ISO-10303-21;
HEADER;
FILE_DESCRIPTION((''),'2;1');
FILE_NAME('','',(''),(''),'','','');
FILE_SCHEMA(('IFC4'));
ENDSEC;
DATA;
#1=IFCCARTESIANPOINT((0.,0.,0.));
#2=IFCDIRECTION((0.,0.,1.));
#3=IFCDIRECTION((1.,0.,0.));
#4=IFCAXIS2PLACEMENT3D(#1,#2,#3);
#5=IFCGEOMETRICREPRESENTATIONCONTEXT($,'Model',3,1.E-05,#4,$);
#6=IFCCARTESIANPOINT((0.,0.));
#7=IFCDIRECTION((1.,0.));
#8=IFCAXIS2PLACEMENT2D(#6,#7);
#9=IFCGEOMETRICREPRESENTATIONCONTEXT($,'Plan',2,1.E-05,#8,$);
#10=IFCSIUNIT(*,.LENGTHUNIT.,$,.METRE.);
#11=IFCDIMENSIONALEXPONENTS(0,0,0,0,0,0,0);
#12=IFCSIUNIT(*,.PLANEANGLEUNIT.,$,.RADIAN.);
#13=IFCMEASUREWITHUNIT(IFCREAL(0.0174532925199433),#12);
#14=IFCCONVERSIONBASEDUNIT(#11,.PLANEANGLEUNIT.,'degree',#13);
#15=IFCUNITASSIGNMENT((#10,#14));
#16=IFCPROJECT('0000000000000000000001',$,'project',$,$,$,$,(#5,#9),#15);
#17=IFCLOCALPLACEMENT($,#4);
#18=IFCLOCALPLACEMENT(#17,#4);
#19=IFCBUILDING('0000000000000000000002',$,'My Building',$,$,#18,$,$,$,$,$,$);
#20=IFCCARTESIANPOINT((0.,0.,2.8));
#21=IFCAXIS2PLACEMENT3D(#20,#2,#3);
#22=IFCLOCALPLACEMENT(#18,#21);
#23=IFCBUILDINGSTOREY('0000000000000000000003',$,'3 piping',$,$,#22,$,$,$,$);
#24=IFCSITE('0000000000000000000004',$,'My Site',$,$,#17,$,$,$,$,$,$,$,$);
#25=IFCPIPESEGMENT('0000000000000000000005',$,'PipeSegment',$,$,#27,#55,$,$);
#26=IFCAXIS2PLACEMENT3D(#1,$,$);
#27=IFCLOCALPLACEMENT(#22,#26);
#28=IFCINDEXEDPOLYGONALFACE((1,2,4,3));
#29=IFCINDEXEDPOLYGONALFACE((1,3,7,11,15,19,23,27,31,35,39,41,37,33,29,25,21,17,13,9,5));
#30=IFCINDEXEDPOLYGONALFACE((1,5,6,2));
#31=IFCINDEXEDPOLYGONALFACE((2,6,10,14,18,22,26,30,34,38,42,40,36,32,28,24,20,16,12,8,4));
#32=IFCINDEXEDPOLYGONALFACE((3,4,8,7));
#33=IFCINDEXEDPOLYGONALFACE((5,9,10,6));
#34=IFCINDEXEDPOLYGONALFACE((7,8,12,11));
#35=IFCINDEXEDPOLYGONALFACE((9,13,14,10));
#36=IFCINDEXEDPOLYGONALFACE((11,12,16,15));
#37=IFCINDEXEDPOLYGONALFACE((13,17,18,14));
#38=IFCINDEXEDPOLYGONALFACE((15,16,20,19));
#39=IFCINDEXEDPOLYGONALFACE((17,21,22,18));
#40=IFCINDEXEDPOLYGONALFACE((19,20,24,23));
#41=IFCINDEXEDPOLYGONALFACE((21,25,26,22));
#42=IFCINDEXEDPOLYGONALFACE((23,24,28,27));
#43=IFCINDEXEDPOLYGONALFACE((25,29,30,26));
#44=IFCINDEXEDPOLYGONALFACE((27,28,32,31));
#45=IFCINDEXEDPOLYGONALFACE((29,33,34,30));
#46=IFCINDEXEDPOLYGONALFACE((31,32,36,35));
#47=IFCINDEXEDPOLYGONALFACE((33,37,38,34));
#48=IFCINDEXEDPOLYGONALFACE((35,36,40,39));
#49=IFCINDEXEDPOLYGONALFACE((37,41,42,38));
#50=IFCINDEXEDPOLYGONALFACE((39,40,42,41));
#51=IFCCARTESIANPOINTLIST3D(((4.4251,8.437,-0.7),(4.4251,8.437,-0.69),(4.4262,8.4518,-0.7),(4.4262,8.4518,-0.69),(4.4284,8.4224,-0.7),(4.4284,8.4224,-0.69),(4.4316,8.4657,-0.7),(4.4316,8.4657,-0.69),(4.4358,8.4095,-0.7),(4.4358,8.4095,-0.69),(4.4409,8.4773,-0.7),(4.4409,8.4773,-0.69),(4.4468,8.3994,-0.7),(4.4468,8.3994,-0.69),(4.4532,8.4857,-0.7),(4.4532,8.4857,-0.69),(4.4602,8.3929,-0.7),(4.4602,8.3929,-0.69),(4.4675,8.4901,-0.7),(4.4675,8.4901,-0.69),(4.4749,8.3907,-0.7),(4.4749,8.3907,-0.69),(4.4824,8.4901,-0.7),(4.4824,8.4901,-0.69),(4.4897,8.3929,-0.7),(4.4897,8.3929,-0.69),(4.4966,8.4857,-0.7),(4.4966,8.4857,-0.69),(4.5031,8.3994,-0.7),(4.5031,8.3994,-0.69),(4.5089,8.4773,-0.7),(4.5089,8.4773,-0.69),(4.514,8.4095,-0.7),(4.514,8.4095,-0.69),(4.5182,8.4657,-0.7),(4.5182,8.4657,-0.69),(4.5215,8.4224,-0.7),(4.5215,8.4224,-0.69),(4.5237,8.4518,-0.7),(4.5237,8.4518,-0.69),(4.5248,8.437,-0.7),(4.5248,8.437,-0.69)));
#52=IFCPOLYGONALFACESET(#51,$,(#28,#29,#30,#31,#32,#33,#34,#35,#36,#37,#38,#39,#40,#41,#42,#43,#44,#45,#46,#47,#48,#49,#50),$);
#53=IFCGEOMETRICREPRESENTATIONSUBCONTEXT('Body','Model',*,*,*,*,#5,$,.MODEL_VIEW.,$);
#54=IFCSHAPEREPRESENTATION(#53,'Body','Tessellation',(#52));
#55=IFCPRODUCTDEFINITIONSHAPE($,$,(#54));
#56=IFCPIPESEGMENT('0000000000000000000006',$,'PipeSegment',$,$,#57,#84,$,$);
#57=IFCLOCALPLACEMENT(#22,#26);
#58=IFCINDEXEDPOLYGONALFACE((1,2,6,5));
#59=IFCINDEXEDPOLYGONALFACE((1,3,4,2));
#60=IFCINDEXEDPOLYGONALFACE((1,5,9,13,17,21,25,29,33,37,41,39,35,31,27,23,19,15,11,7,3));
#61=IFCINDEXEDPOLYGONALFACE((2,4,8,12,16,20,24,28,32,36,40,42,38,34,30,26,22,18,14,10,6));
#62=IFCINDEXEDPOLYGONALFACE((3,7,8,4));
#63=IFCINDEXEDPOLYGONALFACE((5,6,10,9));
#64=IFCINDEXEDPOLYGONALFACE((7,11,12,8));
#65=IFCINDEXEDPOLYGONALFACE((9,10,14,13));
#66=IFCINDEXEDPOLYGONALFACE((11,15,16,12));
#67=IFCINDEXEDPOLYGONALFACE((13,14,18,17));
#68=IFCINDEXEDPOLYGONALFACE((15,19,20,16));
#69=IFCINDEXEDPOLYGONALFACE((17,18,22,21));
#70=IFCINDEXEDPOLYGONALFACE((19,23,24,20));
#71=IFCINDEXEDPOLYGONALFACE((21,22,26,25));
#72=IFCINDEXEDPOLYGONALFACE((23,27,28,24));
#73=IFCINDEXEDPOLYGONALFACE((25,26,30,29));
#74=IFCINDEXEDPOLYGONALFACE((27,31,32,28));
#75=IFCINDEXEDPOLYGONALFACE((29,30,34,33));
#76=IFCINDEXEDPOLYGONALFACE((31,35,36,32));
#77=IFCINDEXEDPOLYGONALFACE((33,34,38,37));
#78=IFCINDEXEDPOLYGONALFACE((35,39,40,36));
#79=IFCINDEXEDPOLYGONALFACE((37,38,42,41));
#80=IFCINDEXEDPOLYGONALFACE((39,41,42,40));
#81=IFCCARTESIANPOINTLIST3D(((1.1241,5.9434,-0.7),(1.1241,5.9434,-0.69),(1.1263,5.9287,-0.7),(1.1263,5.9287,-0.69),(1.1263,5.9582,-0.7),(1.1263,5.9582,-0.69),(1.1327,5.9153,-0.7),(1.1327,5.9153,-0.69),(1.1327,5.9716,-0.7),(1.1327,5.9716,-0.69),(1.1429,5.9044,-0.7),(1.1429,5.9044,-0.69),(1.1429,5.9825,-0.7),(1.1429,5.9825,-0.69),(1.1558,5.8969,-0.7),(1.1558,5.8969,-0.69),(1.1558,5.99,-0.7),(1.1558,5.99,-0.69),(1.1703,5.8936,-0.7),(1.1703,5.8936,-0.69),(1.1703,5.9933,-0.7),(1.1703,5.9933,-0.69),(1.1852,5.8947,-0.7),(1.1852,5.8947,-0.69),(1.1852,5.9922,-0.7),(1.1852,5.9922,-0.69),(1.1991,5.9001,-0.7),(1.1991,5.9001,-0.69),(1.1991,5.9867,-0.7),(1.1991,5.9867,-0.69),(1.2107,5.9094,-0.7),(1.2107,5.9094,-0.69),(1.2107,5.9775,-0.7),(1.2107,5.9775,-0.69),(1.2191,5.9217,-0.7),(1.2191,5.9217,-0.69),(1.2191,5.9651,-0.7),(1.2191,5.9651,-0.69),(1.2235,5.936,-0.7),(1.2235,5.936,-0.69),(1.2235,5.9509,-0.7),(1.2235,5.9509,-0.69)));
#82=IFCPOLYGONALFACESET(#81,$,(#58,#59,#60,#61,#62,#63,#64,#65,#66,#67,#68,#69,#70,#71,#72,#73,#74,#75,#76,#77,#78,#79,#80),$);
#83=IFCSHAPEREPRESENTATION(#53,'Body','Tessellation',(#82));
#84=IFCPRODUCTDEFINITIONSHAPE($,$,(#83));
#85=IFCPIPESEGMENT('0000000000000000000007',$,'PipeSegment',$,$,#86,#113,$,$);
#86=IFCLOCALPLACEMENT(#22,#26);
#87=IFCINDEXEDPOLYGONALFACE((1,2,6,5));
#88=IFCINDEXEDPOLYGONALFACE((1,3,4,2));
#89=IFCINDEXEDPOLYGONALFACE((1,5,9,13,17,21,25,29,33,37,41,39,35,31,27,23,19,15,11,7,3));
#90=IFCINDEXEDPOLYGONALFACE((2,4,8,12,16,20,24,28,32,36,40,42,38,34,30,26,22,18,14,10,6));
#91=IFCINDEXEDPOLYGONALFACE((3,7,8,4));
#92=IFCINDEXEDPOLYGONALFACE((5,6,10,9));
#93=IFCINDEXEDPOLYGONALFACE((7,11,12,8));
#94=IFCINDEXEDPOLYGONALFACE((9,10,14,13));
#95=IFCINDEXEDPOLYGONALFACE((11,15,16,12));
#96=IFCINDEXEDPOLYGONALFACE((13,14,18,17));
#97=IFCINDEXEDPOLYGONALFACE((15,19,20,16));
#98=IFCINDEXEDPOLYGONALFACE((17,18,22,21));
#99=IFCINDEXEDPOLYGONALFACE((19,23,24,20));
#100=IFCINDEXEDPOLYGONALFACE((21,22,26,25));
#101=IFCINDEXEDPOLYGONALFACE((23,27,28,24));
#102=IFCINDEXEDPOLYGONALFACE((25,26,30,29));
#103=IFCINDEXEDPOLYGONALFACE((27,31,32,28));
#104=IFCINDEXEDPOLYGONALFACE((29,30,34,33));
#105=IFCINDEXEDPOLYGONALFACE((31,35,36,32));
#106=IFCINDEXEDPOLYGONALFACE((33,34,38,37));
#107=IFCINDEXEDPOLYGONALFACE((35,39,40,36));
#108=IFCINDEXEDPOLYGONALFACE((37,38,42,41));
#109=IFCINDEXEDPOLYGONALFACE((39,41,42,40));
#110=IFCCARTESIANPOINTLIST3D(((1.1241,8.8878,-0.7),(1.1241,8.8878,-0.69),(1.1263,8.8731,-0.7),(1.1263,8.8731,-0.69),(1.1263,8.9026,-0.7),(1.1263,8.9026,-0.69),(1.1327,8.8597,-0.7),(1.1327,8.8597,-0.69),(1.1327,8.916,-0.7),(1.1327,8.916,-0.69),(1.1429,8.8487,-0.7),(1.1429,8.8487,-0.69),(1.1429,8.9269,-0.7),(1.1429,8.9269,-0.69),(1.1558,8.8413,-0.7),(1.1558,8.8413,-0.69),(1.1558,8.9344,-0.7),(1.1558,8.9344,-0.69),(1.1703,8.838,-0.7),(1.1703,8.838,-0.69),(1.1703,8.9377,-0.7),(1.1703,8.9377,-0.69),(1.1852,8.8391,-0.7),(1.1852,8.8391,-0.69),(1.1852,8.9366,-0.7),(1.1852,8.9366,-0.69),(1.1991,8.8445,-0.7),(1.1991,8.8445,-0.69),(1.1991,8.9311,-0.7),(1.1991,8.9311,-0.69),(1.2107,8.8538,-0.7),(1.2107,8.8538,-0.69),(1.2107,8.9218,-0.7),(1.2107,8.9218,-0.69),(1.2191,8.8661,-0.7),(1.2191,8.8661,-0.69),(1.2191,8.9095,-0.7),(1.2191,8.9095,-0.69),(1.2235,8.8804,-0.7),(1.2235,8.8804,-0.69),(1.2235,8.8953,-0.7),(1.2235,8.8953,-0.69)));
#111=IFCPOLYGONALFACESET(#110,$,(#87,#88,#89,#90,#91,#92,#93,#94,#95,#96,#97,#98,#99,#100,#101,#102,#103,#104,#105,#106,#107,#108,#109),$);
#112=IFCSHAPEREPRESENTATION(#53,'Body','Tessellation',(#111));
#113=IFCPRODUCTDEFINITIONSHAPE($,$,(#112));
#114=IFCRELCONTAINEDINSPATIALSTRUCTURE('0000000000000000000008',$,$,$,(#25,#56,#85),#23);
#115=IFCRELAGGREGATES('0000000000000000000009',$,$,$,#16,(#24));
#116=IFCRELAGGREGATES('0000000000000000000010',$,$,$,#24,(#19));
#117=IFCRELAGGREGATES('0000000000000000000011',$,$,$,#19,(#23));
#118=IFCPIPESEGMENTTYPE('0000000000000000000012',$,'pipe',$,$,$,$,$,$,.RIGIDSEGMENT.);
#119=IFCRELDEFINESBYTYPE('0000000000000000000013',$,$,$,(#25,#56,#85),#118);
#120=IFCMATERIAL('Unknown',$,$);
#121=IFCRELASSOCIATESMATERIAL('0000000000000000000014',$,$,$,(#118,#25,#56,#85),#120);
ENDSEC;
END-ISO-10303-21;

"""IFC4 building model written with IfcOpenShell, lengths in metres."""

from ifc_helpers import new_model, entity, si_unit, converted_unit, frame, origin_with_axes, origin_2d_with_axis, place, context, subcontext, project, spatial, circle, extrude, material, material_profile, profile_set, profile_usage, type_object, element, save


model = new_model("IFC4")

# Units and contexts
model_context = context("Model", 3, precision=1e-05, world=origin_with_axes())
plan_context = context("Plan", 2, precision=1e-05, world=origin_2d_with_axis())
body_context = subcontext(model_context, "Body", "Model", "MODEL_VIEW")
ifc_project = project(units=[si_unit("LENGTHUNIT", "METRE"), converted_unit("PLANEANGLEUNIT", "degree", entity("IfcReal", 0.0174532925199433), si_unit("PLANEANGLEUNIT", "RADIAN"), dimensions=[0, 0, 0, 0, 0, 0, 0])], contexts=[model_context, plan_context])

# Site, building, storey
site_placement = place(None, origin_with_axes())
site = spatial("IfcSite", under=ifc_project, at=site_placement, Name="My Site")
building_placement = place(site_placement, origin_with_axes())
building = spatial("IfcBuilding", under=site, at=building_placement, Name="My Building")
storey_placement = place(building_placement, frame((0.0, 0.0, 2.8), z_axis=(0.0, 0.0, 1.0), x_axis=(1.0, 0.0, 0.0)))
storey = spatial("IfcBuildingStorey", under=building, at=storey_placement, Name="3 piping")

# Pipe segments
ifc_material = material(Name="Unknown")
ifc_material_profile_1 = material_profile(ifc_material, circle(Radius=0.05))
ifc_profile_set_1 = profile_set([ifc_material_profile_1])
pipe_segment_type = type_object("IfcPipeSegmentType", Name="pipe", PredefinedType="RIGIDSEGMENT", material=ifc_profile_set_1)
ifc_profile_usage_1 = profile_usage(ifc_profile_set_1, cardinal=2)
pipe_segment_1_placement = place(storey_placement, frame((4.5249, 8.4407, -0.69), z_axis=(0.0, 0.0, -1.0), x_axis=(0.0, -1.0, 0.0)))
element("IfcPipeSegment", 1, at=pipe_segment_1_placement, inside=storey, type_object=pipe_segment_type, material=ifc_profile_usage_1, Name="PipeSegment", context=body_context, shape_type="SweptSolid", body=[
    extrude(circle(Radius=0.05), frame((0.0, 0.05, 0.0), z_axis=(0.0, 0.0, 1.0), x_axis=(1.0, 0.0, 0.0)), (0.0, 0.0, 1.0), 0.01),
])
ifc_profile_usage_2 = profile_usage(ifc_profile_set_1, cardinal=2)
pipe_segment_2_placement = place(storey_placement, frame((1.1741, 5.8934, -0.69), z_axis=(0.0, 0.0, -1.0), x_axis=(-1.0, 0.0, 0.0)))
element("IfcPipeSegment", 2, at=pipe_segment_2_placement, inside=storey, type_object=pipe_segment_type, material=ifc_profile_usage_2, Name="PipeSegment", context=body_context, shape_type="SweptSolid", body=[
    extrude(circle(Radius=0.05), frame((0.0, 0.05, 0.0), z_axis=(0.0, 0.0, 1.0), x_axis=(1.0, 0.0, 0.0)), (0.0, 0.0, 1.0), 0.01),
])
ifc_profile_usage_3 = profile_usage(ifc_profile_set_1, cardinal=2)
pipe_segment_3_placement = place(storey_placement, frame((1.1741, 8.8378, -0.69), z_axis=(0.0, 0.0, -1.0), x_axis=(-1.0, 0.0, 0.0)))
element("IfcPipeSegment", 3, at=pipe_segment_3_placement, inside=storey, type_object=pipe_segment_type, material=ifc_profile_usage_3, Name="PipeSegment", context=body_context, shape_type="SweptSolid", body=[
    extrude(circle(Radius=0.05), frame((0.0, 0.05, 0.0), z_axis=(0.0, 0.0, 1.0), x_axis=(1.0, 0.0, 0.0)), (0.0, 0.0, 1.0), 0.01),
])

save(model, "model.ifc")
